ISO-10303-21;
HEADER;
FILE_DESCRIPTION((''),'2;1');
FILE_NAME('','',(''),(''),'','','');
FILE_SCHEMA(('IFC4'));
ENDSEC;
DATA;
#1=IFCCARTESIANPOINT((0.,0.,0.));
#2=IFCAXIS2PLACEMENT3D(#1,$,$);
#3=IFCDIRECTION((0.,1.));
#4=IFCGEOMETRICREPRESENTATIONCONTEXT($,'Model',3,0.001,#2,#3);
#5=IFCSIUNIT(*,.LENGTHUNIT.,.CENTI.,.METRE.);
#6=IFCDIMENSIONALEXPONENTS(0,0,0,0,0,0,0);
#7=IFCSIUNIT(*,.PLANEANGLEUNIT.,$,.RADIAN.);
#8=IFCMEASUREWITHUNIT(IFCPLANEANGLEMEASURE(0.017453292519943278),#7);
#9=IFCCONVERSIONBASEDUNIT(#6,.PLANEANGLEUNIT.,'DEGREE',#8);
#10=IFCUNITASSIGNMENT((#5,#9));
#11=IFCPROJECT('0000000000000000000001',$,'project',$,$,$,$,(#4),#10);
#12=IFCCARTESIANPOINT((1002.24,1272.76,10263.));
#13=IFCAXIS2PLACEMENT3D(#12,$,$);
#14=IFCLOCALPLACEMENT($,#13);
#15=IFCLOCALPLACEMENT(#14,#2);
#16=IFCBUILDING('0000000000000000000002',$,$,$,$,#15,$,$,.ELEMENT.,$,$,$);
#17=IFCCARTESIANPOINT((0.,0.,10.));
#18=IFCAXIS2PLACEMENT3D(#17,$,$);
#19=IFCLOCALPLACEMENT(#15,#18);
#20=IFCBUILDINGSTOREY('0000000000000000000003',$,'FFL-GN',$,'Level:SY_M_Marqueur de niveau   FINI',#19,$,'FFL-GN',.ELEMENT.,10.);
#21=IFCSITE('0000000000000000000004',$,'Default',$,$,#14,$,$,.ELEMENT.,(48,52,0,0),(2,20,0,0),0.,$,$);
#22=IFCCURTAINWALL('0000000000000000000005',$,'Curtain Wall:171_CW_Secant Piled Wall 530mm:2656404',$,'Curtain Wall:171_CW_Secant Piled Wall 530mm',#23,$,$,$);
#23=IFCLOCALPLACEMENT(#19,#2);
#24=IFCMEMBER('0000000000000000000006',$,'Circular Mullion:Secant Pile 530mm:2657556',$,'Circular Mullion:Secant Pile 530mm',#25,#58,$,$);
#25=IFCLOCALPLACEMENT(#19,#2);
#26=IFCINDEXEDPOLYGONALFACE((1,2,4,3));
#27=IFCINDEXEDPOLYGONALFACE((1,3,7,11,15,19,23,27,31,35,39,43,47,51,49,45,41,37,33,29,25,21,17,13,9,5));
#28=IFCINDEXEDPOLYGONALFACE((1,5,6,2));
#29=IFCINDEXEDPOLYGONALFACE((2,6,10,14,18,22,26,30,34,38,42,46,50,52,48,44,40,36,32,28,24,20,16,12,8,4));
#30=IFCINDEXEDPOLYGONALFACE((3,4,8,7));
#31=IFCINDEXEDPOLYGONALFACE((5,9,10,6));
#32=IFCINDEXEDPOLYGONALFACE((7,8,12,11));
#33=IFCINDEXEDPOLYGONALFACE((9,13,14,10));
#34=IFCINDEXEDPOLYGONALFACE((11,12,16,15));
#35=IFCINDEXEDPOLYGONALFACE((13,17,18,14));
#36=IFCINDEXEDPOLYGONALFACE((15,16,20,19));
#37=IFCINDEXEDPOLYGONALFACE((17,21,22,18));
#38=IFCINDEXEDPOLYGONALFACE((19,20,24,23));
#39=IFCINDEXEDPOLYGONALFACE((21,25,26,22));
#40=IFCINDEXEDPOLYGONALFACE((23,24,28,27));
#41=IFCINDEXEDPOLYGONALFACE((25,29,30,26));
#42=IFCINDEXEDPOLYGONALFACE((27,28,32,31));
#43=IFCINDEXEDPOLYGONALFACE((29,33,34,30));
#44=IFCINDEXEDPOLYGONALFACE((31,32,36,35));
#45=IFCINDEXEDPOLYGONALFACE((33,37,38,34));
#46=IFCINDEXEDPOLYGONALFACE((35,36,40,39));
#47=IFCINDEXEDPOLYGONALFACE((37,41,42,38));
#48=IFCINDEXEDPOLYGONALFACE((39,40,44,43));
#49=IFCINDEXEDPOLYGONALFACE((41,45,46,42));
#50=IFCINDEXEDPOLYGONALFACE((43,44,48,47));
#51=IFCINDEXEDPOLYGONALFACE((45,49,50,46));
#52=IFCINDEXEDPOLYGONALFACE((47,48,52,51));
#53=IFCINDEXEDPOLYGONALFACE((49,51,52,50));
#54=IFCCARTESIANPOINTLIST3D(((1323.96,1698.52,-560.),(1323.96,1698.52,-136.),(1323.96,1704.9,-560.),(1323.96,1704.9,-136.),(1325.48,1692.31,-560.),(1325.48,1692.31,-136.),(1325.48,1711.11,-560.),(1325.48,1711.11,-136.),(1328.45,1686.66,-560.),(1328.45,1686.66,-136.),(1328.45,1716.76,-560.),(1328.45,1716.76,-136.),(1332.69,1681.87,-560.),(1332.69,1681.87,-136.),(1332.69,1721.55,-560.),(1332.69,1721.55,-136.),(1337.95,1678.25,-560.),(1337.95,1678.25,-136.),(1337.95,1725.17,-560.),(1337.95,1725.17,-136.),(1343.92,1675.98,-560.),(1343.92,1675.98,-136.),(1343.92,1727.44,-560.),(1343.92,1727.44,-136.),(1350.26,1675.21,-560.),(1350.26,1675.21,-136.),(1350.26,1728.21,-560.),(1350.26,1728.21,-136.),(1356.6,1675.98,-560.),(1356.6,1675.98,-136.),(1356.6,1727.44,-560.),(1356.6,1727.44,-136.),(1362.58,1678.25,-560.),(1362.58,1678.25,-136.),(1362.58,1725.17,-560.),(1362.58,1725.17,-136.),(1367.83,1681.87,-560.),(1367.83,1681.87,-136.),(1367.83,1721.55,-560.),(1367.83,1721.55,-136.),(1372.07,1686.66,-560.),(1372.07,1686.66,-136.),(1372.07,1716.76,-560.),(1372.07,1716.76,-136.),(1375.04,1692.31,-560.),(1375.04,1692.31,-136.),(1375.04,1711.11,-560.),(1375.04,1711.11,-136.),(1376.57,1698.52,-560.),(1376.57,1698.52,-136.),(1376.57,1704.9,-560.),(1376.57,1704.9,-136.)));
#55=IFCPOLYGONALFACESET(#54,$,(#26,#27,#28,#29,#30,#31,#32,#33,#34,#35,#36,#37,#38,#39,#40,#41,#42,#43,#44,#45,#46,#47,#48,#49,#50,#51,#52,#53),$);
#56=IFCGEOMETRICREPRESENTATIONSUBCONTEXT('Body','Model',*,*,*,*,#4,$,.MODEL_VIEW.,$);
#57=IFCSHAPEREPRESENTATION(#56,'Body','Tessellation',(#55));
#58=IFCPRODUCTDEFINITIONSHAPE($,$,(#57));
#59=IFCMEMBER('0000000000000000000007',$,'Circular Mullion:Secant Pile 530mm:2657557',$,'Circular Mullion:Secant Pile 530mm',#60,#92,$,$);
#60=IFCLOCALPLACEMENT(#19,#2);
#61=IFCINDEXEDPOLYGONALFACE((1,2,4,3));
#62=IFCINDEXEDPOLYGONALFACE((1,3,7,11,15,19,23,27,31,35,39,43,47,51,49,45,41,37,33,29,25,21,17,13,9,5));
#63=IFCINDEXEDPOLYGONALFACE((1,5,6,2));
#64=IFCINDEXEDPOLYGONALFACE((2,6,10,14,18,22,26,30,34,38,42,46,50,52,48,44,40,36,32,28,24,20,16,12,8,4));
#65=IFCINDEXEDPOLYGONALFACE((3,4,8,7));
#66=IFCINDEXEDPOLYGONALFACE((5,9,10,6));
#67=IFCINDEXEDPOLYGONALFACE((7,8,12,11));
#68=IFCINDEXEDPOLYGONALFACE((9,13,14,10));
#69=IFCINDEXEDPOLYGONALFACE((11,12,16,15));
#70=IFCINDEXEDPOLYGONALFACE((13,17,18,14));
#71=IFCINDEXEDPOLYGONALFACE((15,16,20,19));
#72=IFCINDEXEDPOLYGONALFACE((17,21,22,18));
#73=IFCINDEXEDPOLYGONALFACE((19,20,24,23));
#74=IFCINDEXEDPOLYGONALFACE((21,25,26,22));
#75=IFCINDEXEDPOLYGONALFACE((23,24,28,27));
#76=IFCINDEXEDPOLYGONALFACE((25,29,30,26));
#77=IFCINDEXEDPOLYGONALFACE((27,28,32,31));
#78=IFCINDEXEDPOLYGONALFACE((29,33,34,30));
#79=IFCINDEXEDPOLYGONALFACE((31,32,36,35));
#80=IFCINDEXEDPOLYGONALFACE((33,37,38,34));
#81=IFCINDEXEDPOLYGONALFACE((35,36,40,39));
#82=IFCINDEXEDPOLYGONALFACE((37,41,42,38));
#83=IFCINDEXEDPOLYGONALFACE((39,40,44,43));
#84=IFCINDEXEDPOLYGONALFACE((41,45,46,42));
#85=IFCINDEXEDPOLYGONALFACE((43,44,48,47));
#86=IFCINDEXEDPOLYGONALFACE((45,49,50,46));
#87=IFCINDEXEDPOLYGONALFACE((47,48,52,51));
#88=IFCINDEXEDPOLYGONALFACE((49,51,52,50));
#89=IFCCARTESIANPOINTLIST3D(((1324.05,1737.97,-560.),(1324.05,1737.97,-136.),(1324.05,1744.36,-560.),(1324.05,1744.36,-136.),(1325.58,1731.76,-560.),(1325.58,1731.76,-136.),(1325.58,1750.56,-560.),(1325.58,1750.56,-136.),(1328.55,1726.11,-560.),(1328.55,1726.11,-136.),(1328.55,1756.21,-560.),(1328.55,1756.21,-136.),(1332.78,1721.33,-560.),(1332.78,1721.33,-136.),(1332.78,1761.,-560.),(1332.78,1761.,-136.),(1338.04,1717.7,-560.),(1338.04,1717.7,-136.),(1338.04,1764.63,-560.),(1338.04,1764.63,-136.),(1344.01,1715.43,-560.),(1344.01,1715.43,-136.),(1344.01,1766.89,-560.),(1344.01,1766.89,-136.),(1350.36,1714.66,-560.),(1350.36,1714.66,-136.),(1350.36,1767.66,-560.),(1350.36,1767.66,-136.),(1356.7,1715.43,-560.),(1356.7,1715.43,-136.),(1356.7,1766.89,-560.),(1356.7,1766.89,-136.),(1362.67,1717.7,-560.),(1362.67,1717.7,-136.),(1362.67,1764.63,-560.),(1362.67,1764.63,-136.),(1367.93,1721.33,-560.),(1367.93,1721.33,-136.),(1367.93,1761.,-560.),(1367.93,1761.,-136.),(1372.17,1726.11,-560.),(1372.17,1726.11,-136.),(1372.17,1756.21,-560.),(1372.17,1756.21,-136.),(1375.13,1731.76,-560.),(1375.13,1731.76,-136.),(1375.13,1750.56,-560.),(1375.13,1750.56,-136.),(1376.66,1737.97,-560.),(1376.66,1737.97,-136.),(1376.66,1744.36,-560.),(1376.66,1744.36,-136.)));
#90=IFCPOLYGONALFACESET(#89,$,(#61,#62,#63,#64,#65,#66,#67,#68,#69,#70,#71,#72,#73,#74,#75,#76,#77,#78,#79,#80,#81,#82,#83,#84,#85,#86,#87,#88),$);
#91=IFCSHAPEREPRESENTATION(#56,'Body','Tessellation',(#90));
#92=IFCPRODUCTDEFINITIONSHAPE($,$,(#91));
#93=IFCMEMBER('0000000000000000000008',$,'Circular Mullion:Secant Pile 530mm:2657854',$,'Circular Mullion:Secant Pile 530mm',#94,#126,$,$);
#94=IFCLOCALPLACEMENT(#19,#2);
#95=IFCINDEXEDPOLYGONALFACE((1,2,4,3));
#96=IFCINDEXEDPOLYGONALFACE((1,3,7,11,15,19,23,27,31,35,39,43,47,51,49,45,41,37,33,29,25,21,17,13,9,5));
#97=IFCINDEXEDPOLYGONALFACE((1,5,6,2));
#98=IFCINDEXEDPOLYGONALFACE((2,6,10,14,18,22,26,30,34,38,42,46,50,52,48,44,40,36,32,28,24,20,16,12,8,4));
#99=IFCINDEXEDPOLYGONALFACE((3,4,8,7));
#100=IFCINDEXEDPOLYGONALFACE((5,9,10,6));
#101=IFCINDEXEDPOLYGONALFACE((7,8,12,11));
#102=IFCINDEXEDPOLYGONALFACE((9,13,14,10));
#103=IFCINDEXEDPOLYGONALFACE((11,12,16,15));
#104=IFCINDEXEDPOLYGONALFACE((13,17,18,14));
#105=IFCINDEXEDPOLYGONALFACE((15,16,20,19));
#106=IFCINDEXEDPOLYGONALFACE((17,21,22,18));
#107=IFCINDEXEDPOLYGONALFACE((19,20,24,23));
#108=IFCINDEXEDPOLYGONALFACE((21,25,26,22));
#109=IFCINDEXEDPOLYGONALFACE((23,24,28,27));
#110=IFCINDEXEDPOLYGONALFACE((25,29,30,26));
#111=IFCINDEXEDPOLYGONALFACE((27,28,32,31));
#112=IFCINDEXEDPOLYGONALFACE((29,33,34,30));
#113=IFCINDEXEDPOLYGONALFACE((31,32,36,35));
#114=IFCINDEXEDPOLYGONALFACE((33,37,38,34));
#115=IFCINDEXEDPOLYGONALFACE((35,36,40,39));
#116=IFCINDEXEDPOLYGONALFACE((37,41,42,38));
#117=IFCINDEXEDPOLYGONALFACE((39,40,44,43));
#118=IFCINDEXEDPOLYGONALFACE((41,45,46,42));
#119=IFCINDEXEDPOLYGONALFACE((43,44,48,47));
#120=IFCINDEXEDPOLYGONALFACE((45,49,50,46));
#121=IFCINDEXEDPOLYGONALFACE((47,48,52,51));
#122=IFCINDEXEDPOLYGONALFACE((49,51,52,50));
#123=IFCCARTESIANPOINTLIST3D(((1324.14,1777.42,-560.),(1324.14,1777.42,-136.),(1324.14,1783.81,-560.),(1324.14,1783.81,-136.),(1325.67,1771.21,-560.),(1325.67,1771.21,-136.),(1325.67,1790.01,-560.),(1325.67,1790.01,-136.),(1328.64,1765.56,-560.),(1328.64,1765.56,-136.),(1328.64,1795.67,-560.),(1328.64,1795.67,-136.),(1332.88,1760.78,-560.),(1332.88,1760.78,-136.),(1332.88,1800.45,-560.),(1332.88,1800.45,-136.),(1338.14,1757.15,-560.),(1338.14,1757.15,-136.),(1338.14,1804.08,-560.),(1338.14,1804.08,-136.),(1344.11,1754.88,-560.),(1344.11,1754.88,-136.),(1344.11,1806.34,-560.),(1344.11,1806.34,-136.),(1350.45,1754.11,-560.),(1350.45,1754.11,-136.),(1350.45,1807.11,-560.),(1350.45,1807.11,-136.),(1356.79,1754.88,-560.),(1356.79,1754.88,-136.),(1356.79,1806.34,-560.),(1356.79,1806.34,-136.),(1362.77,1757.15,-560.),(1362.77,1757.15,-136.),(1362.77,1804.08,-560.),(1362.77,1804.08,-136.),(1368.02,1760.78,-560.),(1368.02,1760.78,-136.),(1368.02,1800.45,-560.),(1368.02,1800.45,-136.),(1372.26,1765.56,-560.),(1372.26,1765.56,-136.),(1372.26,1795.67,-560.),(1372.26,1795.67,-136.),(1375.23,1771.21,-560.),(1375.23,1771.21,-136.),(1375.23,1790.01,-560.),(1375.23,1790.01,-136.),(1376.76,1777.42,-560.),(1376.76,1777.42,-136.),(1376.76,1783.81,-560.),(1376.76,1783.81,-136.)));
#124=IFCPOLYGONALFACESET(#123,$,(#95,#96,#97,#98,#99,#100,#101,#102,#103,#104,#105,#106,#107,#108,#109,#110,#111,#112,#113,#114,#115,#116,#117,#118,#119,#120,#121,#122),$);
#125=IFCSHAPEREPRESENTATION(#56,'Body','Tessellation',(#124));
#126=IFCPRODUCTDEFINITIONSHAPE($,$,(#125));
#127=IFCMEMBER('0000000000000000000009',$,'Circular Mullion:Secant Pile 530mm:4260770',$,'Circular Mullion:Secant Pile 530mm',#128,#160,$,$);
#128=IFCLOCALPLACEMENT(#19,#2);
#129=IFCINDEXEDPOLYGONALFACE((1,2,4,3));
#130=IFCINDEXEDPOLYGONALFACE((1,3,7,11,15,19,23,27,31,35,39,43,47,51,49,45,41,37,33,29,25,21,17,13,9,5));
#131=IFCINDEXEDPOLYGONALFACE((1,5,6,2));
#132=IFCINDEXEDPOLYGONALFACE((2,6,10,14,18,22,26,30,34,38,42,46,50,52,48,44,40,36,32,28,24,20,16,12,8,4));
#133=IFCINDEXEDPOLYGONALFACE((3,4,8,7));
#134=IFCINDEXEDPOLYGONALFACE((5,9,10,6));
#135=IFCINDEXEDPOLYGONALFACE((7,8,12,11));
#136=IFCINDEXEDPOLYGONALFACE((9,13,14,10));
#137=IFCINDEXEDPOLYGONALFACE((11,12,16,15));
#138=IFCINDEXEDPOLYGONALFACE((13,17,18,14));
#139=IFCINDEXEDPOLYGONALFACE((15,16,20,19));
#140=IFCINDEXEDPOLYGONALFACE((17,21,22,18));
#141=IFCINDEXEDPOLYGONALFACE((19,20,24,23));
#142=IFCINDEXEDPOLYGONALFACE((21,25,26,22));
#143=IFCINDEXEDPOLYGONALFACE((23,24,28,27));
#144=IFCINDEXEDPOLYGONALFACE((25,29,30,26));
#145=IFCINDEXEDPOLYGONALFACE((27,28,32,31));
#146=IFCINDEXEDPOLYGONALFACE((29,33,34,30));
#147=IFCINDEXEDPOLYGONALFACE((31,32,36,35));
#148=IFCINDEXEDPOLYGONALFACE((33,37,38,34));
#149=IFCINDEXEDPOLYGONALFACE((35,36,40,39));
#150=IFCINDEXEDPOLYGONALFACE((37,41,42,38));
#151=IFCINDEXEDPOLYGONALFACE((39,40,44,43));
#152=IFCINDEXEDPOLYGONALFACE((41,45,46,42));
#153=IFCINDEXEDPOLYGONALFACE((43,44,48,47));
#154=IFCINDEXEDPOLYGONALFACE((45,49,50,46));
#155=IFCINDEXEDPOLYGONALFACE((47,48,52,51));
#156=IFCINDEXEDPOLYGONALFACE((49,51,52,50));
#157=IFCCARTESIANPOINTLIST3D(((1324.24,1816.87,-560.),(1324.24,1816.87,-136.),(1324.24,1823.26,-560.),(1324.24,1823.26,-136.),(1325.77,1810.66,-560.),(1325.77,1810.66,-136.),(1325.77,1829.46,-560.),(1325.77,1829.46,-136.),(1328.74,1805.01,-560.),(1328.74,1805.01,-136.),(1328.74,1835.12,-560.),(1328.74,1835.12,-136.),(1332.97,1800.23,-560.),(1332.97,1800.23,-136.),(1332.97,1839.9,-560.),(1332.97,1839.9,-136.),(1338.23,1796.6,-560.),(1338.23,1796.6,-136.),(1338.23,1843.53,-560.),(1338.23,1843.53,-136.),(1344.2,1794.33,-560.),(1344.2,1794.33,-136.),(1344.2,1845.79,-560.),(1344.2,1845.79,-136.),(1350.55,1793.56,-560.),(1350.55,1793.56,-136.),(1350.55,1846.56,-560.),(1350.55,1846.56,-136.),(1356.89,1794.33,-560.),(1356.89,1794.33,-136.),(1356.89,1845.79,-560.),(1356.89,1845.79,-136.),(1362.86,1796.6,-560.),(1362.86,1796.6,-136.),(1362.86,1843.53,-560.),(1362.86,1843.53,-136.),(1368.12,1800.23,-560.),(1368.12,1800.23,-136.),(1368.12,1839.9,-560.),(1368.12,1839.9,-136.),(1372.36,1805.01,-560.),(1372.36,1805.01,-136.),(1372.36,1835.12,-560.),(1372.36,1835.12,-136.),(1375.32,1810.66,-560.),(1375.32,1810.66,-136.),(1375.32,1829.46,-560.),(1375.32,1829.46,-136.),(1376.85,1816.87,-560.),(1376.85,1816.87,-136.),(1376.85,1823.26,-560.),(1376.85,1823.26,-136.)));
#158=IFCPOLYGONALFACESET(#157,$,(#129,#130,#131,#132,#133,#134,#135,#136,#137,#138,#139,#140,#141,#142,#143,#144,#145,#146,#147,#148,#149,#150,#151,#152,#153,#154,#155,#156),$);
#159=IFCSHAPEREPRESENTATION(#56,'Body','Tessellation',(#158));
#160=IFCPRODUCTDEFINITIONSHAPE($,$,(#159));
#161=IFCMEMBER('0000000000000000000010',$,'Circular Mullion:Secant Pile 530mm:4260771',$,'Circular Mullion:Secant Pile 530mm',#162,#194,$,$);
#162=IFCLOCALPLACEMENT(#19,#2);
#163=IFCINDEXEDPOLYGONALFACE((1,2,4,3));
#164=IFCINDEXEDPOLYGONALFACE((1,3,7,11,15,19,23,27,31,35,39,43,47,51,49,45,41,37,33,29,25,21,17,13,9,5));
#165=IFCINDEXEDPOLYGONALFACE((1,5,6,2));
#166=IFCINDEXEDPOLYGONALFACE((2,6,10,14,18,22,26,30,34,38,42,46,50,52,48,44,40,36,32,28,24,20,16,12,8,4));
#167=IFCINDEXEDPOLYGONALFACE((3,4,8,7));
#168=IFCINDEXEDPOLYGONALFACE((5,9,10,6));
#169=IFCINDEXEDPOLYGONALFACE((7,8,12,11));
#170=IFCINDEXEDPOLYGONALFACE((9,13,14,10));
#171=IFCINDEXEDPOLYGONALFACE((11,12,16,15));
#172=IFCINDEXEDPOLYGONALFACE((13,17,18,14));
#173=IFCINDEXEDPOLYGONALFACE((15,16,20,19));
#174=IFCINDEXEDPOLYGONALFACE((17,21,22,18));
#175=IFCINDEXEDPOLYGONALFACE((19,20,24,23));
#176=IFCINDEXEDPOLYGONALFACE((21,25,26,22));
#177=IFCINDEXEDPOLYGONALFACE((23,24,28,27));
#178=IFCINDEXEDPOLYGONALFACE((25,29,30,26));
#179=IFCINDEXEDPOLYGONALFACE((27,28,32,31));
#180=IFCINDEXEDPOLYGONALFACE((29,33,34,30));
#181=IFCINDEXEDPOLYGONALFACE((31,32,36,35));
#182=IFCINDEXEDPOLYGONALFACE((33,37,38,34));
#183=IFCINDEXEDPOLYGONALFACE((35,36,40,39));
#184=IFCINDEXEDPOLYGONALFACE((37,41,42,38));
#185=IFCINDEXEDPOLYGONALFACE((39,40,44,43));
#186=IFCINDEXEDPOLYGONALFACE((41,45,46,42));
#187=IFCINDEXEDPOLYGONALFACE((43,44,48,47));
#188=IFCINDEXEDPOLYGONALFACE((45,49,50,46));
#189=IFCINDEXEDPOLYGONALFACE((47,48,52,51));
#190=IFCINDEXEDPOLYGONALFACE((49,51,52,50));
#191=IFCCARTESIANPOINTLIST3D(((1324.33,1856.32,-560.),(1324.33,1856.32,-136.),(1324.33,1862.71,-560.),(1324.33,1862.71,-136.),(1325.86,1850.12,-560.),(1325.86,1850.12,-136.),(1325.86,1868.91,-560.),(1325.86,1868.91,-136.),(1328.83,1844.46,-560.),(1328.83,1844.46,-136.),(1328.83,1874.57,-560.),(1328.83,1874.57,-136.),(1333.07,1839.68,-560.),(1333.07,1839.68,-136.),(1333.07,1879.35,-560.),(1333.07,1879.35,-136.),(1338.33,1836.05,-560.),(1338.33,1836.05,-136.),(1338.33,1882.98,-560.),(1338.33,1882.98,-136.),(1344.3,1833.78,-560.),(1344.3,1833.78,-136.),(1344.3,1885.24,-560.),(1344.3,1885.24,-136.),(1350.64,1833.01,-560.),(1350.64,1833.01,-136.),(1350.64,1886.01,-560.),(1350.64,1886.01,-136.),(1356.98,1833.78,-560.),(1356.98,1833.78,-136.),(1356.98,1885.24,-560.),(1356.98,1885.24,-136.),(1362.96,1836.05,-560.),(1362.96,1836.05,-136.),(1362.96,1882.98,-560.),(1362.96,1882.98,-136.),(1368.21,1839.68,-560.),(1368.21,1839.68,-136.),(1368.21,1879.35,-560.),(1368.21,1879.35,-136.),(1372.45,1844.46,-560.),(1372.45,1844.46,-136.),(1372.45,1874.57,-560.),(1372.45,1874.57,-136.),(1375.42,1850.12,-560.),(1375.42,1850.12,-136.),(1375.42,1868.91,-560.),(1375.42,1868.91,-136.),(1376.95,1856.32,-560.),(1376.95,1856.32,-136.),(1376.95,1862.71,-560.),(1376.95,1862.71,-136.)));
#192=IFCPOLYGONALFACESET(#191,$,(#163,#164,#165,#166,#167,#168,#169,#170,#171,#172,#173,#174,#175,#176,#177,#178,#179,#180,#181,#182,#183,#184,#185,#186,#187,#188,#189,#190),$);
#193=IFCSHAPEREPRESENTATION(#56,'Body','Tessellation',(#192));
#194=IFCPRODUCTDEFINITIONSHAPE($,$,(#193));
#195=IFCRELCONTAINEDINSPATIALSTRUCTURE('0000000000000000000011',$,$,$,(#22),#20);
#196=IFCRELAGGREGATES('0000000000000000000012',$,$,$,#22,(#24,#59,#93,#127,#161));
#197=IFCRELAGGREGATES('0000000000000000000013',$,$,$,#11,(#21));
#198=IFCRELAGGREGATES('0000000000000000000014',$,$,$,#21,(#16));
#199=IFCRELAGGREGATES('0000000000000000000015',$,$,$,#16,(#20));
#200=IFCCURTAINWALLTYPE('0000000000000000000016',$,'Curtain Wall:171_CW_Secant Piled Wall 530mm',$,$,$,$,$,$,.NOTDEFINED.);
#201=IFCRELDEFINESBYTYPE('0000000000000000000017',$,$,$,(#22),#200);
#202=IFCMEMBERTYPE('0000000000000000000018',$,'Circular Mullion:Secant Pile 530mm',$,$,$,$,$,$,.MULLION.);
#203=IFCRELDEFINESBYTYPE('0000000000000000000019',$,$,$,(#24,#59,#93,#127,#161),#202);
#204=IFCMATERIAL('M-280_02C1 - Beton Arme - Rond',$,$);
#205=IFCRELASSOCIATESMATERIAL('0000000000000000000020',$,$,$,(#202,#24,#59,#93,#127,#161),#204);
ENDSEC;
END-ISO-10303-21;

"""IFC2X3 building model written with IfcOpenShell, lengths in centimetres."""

from ifc_helpers import new_model, entity, si_unit, converted_unit, direction, frame, frame_2d, origin, place, context, subcontext, project, spatial, circle, extrude, source, transform, mapped, material, type_object, type_shapes, element, aggregate, save


model = new_model("IFC2X3")

# Units and contexts
model_context = context("Model", 3, precision=0.001, world=origin(), true_north=direction((0.0, 1.0)))
body_context = subcontext(model_context, "Body", "Model", "MODEL_VIEW")
ifc_project = project(units=[si_unit("LENGTHUNIT", "METRE", prefix="CENTI"), converted_unit("PLANEANGLEUNIT", "DEGREE", entity("IfcPlaneAngleMeasure", 0.017453292519943278), si_unit("PLANEANGLEUNIT", "RADIAN"), dimensions=[0, 0, 0, 0, 0, 0, 0])], contexts=[model_context])

# Site, building, storey
site_placement = place(None, frame((1002.24, 1272.76, 10263.0)))
site = spatial("IfcSite", under=ifc_project, at=site_placement, Name="Default", CompositionType="ELEMENT", RefLatitude=(48, 52, 0, 0), RefLongitude=(2, 20, 0, 0), RefElevation=0.0)
building_placement = place(site_placement, origin())
building = spatial("IfcBuilding", under=site, at=building_placement, CompositionType="ELEMENT")
storey_placement = place(building_placement, frame((0.0, 0.0, 10.0)))
storey = spatial("IfcBuildingStorey", under=building, at=storey_placement, Name="FFL-GN", ObjectType="Level:SY_M_Marqueur de niveau   FINI", LongName="FFL-GN", CompositionType="ELEMENT", Elevation=10.0)

# Curtain wall, members
curtain_wall_type = type_object("IfcCurtainWallType", Name="Curtain Wall:171_CW_Secant Piled Wall 530mm", PredefinedType="NOTDEFINED")
curtain_wall_1_placement = place(storey_placement, frame((0.0, 0.0, -10.0)))
curtain_wall_1 = element("IfcCurtainWall", 1, at=curtain_wall_1_placement, inside=storey, type_object=curtain_wall_type, Name="Curtain Wall:171_CW_Secant Piled Wall 530mm:2656404", ObjectType="Curtain Wall:171_CW_Secant Piled Wall 530mm")
ifc_material_1 = material(Name="M-280_02C1 - Beton Arme - Rond")
member_type = type_object("IfcMemberType", Name="Circular Mullion:Secant Pile 530mm", PredefinedType="MULLION", material=ifc_material_1)
shared_shape = source(origin(), body_context, "Body", "SweptSolid", [
    extrude(circle(Radius=26.5, at=frame_2d((0.0, 0.0), x_axis=(1.0, 0.0))), frame((0.0, 0.0, -424.0)), (0.0, 0.0, 1.0), 424.0),
])
type_shapes(member_type, [shared_shape])
member_1_placement = place(curtain_wall_1_placement, frame((1350.26, 1701.71, -550.0), z_axis=(0.0, 0.0, -1.0), x_axis=(0.0, 1.0, 0.0)))
member_1 = element("IfcMember", 2, at=member_1_placement, type_object=member_type, material=ifc_material_1, Name="Circular Mullion:Secant Pile 530mm:2657556", ObjectType="Circular Mullion:Secant Pile 530mm", context=body_context, shape_type="MappedRepresentation", body=[
    mapped(shared_shape, transform((0.0, 0.0, 0.0), scale=1.0)),
])
member_2_placement = place(curtain_wall_1_placement, frame((1350.36, 1741.16, -550.0), z_axis=(0.0, 0.0, -1.0), x_axis=(0.0, 1.0, 0.0)))
member_2 = element("IfcMember", 3, at=member_2_placement, type_object=member_type, material=ifc_material_1, Name="Circular Mullion:Secant Pile 530mm:2657557", ObjectType="Circular Mullion:Secant Pile 530mm", context=body_context, shape_type="MappedRepresentation", body=[
    mapped(shared_shape, transform((0.0, 0.0, 0.0), scale=1.0)),
])
member_3_placement = place(curtain_wall_1_placement, frame((1350.45, 1780.61, -550.0), z_axis=(0.0, 0.0, -1.0), x_axis=(0.0, 1.0, 0.0)))
member_3 = element("IfcMember", 4, at=member_3_placement, type_object=member_type, material=ifc_material_1, Name="Circular Mullion:Secant Pile 530mm:2657854", ObjectType="Circular Mullion:Secant Pile 530mm", context=body_context, shape_type="MappedRepresentation", body=[
    mapped(shared_shape, transform((0.0, 0.0, 0.0), scale=1.0)),
])
member_4_placement = place(curtain_wall_1_placement, frame((1350.55, 1820.06, -550.0), z_axis=(0.0, 0.0, -1.0), x_axis=(0.0, 1.0, 0.0)))
member_4 = element("IfcMember", 5, at=member_4_placement, type_object=member_type, material=ifc_material_1, Name="Circular Mullion:Secant Pile 530mm:4260770", ObjectType="Circular Mullion:Secant Pile 530mm", context=body_context, shape_type="MappedRepresentation", body=[
    mapped(shared_shape, transform((0.0, 0.0, 0.0), scale=1.0)),
])
member_5_placement = place(curtain_wall_1_placement, frame((1350.64, 1859.51, -550.0), z_axis=(0.0, 0.0, -1.0), x_axis=(0.0, 1.0, 0.0)))
member_5 = element("IfcMember", 6, at=member_5_placement, type_object=member_type, material=ifc_material_1, Name="Circular Mullion:Secant Pile 530mm:4260771", ObjectType="Circular Mullion:Secant Pile 530mm", context=body_context, shape_type="MappedRepresentation", body=[
    mapped(shared_shape, transform((0.0, 0.0, 0.0), scale=1.0)),
])
aggregate(curtain_wall_1, [member_1, member_2, member_3, member_4, member_5])

save(model, "model.ifc")
